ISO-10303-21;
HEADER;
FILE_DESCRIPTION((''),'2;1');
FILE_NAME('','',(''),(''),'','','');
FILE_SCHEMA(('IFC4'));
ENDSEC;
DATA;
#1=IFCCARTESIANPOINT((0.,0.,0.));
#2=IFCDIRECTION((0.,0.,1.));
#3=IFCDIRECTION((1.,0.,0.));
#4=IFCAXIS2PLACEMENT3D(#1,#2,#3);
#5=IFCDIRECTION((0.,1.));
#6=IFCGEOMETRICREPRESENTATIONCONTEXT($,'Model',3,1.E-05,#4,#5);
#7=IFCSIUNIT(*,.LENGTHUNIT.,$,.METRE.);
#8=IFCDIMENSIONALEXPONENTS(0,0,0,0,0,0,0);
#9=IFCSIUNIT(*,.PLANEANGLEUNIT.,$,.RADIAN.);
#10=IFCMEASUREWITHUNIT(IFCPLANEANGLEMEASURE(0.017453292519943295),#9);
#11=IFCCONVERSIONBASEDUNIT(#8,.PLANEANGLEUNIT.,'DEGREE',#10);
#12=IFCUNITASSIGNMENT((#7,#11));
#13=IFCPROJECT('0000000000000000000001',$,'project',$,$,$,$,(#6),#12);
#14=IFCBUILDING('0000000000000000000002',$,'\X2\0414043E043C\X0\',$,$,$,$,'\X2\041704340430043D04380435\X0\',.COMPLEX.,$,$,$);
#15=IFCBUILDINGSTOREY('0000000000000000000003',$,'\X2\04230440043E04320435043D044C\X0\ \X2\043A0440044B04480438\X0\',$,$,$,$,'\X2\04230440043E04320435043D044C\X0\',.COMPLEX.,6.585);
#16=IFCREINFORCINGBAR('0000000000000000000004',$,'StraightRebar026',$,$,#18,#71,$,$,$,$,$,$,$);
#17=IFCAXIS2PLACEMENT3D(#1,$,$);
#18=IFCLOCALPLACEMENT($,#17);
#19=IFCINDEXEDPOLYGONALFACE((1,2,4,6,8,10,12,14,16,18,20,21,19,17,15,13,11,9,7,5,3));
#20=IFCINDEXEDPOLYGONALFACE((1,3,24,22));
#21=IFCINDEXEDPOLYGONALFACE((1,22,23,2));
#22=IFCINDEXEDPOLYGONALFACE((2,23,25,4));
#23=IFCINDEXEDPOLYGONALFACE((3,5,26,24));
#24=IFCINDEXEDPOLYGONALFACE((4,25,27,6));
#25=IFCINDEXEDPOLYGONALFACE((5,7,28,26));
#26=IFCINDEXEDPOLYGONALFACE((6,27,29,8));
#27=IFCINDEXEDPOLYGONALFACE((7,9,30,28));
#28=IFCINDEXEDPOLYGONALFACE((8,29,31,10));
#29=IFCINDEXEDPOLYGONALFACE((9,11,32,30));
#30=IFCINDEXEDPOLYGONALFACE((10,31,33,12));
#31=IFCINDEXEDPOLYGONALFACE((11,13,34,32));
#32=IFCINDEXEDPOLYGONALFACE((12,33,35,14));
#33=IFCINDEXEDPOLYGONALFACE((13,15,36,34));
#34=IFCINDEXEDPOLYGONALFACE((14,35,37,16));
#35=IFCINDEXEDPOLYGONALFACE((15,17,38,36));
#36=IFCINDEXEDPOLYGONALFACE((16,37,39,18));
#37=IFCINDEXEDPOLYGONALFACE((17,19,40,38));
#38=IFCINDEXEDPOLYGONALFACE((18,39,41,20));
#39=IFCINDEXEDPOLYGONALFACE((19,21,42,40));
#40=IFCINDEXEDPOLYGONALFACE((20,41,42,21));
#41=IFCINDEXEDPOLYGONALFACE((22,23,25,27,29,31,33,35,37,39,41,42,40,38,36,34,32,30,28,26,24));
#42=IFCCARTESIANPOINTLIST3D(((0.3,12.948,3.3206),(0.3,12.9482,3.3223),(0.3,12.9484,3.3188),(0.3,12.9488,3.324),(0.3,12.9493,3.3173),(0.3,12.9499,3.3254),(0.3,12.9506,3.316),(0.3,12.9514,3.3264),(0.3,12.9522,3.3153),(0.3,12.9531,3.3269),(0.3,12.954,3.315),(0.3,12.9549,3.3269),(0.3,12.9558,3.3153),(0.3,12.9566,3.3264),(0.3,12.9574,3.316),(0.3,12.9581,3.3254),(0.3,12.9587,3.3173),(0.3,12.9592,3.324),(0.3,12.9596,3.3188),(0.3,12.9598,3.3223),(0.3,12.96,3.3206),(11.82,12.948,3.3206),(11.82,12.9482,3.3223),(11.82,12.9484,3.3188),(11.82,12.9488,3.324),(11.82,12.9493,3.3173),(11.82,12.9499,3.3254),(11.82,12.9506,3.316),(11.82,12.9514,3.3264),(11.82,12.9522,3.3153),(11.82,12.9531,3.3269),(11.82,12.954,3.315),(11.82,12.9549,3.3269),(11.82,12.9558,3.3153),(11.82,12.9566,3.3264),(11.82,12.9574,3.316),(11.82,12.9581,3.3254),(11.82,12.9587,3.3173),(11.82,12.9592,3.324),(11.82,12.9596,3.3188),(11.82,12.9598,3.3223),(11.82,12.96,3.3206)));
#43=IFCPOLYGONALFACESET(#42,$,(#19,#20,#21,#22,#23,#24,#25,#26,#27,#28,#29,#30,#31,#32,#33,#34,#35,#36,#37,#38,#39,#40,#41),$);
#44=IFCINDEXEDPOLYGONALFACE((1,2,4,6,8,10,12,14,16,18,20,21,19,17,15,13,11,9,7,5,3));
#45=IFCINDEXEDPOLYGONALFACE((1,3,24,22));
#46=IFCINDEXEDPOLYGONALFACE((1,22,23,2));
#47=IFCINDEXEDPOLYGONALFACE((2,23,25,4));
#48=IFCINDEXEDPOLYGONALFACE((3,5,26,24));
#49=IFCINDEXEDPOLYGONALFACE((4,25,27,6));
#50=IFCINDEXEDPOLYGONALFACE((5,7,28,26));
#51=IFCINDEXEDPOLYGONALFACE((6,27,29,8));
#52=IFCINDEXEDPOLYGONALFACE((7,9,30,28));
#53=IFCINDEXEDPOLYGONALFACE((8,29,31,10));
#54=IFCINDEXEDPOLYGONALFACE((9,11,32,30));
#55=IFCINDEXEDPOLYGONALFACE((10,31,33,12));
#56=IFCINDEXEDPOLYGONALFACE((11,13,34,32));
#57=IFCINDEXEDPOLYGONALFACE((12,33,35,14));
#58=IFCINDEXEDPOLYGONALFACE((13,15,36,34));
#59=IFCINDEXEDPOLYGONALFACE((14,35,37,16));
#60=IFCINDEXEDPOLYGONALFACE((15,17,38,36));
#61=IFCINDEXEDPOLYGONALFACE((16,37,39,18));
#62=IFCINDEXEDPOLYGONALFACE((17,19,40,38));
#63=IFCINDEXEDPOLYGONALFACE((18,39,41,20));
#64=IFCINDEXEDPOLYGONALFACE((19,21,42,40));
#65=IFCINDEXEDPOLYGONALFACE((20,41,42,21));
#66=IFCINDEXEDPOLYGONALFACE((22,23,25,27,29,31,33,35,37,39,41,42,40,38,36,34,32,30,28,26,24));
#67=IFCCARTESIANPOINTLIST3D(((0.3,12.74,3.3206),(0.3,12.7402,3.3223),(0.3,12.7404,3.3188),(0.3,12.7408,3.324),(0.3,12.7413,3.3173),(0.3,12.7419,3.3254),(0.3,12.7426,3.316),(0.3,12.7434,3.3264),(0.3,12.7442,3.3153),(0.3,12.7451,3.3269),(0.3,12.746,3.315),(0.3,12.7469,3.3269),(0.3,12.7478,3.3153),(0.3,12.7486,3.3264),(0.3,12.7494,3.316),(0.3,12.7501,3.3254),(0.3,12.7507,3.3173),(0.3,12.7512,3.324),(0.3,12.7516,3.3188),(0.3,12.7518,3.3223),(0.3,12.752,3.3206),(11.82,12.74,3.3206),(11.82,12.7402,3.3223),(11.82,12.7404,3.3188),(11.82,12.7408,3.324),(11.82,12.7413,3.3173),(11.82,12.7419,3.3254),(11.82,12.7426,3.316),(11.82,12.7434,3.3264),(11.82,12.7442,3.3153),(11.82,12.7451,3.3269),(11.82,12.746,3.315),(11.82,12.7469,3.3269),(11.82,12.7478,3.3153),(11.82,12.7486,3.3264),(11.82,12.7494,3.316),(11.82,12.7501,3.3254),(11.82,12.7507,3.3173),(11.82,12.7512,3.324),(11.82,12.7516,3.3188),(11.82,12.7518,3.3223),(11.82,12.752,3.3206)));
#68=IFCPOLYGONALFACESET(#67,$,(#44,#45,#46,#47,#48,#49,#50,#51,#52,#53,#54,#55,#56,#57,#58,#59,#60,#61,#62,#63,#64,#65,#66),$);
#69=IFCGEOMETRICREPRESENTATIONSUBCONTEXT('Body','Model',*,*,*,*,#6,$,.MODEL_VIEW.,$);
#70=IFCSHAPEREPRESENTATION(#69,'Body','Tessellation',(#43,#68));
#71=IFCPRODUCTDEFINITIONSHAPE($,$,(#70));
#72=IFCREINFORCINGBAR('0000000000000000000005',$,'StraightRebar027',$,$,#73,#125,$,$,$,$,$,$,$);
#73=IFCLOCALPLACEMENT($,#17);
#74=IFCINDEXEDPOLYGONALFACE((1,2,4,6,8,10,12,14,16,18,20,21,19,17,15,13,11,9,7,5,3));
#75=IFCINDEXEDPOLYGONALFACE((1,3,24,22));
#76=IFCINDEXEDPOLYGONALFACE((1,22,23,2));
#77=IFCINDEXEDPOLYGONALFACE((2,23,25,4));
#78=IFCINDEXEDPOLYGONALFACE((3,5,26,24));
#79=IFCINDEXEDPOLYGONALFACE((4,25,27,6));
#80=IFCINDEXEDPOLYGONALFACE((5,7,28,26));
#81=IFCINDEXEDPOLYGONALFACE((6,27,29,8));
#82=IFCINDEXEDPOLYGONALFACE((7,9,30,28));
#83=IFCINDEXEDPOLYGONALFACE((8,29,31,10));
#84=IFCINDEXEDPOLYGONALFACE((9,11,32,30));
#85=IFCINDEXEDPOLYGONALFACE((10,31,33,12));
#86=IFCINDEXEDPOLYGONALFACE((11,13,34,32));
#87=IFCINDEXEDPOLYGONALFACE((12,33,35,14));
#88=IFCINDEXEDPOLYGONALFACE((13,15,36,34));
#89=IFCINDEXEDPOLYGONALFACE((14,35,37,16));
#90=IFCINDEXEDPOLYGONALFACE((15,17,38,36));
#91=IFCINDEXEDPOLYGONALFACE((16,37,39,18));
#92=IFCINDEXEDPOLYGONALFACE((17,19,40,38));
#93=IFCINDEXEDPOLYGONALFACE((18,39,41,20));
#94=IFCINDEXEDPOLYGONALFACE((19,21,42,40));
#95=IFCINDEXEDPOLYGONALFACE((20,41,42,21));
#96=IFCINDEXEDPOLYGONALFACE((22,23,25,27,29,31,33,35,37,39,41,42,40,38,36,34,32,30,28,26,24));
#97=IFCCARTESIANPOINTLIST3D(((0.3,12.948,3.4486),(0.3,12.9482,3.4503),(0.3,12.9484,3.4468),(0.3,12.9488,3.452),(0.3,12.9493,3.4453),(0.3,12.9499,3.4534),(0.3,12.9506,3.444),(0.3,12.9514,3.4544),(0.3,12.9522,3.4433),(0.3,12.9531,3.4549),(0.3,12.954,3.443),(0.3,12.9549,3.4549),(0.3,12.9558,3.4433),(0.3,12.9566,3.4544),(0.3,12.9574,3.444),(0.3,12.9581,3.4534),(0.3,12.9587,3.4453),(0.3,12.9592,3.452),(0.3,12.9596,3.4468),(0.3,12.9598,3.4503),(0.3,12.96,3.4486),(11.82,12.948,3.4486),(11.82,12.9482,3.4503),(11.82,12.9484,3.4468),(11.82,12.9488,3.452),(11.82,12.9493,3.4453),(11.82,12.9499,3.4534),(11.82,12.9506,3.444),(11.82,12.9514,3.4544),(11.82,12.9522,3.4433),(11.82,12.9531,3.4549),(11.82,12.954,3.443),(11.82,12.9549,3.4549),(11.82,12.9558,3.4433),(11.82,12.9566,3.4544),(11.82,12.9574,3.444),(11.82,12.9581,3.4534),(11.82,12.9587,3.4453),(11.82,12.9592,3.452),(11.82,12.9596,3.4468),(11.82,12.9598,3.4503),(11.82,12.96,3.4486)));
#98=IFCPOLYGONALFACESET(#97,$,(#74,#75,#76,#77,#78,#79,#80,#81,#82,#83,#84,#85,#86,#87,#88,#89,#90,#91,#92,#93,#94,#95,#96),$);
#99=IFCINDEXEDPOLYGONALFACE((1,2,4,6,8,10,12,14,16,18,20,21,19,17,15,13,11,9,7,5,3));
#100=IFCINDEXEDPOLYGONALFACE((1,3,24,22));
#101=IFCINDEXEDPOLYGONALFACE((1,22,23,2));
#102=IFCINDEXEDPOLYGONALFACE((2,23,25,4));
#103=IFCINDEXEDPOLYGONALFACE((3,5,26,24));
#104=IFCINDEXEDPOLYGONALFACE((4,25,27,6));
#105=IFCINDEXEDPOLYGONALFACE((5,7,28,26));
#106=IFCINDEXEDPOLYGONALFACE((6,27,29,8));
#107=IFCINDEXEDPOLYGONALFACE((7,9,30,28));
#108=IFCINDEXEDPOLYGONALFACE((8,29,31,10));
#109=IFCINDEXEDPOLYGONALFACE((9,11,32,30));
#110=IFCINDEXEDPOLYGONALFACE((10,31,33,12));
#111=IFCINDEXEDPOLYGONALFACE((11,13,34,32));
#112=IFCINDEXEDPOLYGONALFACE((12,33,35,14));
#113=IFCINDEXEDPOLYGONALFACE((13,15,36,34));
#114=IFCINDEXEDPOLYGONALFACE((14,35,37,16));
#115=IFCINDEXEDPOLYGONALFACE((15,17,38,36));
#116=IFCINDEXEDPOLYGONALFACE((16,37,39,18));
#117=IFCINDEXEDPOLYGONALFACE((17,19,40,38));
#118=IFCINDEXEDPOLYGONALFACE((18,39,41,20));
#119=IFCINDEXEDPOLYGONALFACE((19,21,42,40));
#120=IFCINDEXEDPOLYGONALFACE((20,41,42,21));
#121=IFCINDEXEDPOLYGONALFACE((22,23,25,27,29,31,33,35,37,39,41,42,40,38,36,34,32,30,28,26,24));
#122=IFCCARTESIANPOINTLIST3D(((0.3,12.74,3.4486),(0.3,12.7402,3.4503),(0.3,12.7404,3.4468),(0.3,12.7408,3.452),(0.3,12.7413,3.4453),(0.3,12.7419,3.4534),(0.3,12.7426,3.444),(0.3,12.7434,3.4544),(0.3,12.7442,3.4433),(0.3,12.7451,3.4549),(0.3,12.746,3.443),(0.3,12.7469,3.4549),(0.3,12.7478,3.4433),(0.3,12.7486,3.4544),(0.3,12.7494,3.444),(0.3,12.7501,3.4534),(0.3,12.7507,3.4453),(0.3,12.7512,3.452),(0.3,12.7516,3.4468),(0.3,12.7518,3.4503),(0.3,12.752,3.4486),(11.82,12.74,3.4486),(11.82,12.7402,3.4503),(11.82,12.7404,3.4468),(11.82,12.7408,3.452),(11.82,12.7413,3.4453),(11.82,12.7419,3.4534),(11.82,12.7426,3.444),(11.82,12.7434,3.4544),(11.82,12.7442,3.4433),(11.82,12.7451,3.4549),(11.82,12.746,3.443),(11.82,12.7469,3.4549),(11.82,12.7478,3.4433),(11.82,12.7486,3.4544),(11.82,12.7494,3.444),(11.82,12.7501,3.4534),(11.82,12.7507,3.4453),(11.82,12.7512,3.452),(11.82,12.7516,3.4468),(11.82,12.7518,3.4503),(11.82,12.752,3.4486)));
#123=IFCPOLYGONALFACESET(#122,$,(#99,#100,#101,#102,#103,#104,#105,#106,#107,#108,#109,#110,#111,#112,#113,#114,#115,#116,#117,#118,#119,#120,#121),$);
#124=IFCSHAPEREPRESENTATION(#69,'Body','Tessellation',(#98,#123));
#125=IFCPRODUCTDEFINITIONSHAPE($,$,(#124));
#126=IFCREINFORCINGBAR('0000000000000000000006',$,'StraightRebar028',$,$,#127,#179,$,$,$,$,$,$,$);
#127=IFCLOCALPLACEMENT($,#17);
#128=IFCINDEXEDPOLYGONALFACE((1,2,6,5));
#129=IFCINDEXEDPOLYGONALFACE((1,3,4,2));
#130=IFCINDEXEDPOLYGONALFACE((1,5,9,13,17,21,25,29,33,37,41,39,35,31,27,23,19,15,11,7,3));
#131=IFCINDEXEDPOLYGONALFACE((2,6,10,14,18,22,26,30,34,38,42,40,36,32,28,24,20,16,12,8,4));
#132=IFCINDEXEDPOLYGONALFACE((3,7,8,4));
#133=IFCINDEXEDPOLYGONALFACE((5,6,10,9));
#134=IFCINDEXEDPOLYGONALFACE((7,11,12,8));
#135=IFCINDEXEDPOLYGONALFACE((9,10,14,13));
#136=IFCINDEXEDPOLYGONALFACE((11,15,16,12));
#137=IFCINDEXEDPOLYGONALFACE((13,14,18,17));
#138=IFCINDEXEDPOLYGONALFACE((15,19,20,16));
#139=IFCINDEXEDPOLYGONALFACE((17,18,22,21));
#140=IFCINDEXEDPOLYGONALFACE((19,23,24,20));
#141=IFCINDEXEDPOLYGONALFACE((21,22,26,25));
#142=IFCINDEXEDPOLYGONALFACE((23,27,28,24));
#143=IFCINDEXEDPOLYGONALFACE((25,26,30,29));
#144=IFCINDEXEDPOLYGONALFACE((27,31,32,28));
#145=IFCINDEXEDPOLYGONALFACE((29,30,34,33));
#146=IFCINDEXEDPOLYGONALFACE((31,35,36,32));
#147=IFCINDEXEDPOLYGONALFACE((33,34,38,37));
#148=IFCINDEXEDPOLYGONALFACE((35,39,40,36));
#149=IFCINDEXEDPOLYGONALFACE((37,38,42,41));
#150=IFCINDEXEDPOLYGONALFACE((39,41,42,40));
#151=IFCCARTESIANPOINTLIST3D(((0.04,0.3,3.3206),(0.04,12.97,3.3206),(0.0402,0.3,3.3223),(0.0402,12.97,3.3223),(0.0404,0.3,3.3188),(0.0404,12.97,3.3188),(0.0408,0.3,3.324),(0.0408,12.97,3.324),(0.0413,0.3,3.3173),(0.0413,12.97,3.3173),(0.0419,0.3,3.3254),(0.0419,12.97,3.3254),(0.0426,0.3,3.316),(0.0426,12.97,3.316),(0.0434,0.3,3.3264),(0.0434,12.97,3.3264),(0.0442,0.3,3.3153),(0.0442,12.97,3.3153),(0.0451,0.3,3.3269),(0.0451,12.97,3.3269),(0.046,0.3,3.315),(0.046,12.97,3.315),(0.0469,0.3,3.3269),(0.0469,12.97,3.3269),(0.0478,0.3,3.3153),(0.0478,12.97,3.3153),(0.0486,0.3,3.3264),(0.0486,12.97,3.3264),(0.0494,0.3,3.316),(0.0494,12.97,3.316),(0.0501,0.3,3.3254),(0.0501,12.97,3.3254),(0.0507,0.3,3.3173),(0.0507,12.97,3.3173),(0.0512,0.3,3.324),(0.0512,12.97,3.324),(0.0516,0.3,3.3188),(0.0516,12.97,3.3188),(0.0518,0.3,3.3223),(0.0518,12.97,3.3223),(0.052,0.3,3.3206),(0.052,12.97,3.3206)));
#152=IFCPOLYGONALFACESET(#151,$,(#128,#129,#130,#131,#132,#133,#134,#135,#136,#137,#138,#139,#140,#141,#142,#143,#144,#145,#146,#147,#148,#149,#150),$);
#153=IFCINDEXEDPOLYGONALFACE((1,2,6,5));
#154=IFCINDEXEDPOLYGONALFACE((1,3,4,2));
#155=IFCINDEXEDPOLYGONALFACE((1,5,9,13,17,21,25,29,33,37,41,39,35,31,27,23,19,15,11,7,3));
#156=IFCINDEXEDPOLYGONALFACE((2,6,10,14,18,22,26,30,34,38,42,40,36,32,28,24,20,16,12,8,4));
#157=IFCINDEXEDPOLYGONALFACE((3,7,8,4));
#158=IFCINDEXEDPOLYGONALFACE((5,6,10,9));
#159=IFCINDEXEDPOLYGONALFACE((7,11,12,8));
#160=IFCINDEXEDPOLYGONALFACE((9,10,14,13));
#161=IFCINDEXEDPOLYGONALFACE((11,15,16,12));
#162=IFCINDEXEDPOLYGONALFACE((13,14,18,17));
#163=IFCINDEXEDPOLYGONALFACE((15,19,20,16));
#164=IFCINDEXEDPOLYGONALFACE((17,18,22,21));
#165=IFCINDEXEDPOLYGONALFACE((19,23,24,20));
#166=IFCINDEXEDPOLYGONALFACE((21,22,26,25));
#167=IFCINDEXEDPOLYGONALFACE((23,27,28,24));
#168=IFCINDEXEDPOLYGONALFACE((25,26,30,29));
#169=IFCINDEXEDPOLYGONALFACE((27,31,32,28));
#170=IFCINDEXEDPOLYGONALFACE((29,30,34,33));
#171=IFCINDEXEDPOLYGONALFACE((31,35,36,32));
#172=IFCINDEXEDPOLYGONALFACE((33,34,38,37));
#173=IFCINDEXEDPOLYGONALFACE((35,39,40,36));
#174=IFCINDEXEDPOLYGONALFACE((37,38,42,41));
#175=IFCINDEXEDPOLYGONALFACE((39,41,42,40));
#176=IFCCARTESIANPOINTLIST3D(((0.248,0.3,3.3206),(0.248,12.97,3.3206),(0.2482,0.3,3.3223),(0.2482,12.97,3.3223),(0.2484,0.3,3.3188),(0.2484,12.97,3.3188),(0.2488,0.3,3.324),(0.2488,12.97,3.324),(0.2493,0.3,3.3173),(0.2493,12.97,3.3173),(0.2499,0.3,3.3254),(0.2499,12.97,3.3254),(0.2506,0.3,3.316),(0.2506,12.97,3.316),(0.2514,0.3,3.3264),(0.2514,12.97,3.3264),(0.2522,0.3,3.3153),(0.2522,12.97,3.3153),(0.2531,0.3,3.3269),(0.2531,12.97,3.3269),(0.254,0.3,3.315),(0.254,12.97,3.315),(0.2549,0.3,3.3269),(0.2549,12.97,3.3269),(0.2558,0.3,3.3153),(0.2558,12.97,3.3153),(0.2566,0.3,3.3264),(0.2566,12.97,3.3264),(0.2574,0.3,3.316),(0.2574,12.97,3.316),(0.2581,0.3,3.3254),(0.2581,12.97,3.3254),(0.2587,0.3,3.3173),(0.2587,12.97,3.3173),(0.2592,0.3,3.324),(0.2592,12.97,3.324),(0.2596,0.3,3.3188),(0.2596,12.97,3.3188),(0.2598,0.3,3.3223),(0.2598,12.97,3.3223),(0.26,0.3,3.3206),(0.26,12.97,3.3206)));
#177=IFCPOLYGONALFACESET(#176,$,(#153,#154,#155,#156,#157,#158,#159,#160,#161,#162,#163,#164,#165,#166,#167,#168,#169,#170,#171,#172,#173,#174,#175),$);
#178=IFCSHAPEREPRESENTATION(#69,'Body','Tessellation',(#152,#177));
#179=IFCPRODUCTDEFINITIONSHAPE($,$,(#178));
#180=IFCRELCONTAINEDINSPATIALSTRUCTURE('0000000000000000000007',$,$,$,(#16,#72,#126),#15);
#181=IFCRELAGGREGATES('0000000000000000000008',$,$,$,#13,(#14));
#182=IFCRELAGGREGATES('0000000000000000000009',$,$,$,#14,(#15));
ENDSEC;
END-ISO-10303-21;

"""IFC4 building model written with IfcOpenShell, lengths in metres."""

from ifc_helpers import new_model, entity, si_unit, converted_unit, direction, origin_with_axes, place, context, subcontext, project, spatial, element, save


model = new_model("IFC4")

# Units and contexts
model_context = context("Model", 3, precision=1e-05, world=origin_with_axes(), true_north=direction((0.0, 1.0)))
body_context = subcontext(model_context, "Body", "Model", "MODEL_VIEW")
ifc_project = project(units=[si_unit("LENGTHUNIT", "METRE"), converted_unit("PLANEANGLEUNIT", "DEGREE", entity("IfcPlaneAngleMeasure", 0.017453292519943295), si_unit("PLANEANGLEUNIT", "RADIAN"), dimensions=[0, 0, 0, 0, 0, 0, 0])], contexts=[model_context])

# Building, storey
building = spatial("IfcBuilding", under=ifc_project, Name="Дом", LongName="Здание", CompositionType="COMPLEX")
storey = spatial("IfcBuildingStorey", under=building, Name="Уровень крыши", LongName="Уровень", CompositionType="COMPLEX", Elevation=6.585)

# Shared definitions
placement = place(None, origin_with_axes())

# Reinforcing bars
element("IfcReinforcingBar", 1, at=placement, inside=storey, Name="StraightRebar026", context=body_context, shape_type="SweptSolid", body=[
    entity("IfcSweptDiskSolid", entity("IfcCompositeCurve", [entity("IfcCompositeCurveSegment", "CONTINUOUS", True, entity("IfcPolyline", [entity("IfcCartesianPoint", [11.82, 12.954, 3.321]), entity("IfcCartesianPoint", [0.3, 12.954, 3.321])]))], False), 0.006),
    entity("IfcSweptDiskSolid", entity("IfcCompositeCurve", [entity("IfcCompositeCurveSegment", "CONTINUOUS", True, entity("IfcPolyline", [entity("IfcCartesianPoint", [11.82, 12.746, 3.321]), entity("IfcCartesianPoint", [0.3, 12.746, 3.321])]))], False), 0.006),
])
element("IfcReinforcingBar", 2, at=placement, inside=storey, Name="StraightRebar027", context=body_context, shape_type="SweptSolid", body=[
    entity("IfcSweptDiskSolid", entity("IfcCompositeCurve", [entity("IfcCompositeCurveSegment", "CONTINUOUS", True, entity("IfcPolyline", [entity("IfcCartesianPoint", [11.82, 12.954, 3.449]), entity("IfcCartesianPoint", [0.3, 12.954, 3.449])]))], False), 0.006),
    entity("IfcSweptDiskSolid", entity("IfcCompositeCurve", [entity("IfcCompositeCurveSegment", "CONTINUOUS", True, entity("IfcPolyline", [entity("IfcCartesianPoint", [11.82, 12.746, 3.449]), entity("IfcCartesianPoint", [0.3, 12.746, 3.449])]))], False), 0.006),
])
element("IfcReinforcingBar", 3, at=placement, inside=storey, Name="StraightRebar028", context=body_context, shape_type="SweptSolid", body=[
    entity("IfcSweptDiskSolid", entity("IfcCompositeCurve", [entity("IfcCompositeCurveSegment", "CONTINUOUS", True, entity("IfcPolyline", [entity("IfcCartesianPoint", [0.046, 12.97, 3.321]), entity("IfcCartesianPoint", [0.046, 0.3, 3.321])]))], False), 0.006),
    entity("IfcSweptDiskSolid", entity("IfcCompositeCurve", [entity("IfcCompositeCurveSegment", "CONTINUOUS", True, entity("IfcPolyline", [entity("IfcCartesianPoint", [0.254, 12.97, 3.321]), entity("IfcCartesianPoint", [0.254, 0.3, 3.321])]))], False), 0.006),
])

save(model, "model.ifc")
